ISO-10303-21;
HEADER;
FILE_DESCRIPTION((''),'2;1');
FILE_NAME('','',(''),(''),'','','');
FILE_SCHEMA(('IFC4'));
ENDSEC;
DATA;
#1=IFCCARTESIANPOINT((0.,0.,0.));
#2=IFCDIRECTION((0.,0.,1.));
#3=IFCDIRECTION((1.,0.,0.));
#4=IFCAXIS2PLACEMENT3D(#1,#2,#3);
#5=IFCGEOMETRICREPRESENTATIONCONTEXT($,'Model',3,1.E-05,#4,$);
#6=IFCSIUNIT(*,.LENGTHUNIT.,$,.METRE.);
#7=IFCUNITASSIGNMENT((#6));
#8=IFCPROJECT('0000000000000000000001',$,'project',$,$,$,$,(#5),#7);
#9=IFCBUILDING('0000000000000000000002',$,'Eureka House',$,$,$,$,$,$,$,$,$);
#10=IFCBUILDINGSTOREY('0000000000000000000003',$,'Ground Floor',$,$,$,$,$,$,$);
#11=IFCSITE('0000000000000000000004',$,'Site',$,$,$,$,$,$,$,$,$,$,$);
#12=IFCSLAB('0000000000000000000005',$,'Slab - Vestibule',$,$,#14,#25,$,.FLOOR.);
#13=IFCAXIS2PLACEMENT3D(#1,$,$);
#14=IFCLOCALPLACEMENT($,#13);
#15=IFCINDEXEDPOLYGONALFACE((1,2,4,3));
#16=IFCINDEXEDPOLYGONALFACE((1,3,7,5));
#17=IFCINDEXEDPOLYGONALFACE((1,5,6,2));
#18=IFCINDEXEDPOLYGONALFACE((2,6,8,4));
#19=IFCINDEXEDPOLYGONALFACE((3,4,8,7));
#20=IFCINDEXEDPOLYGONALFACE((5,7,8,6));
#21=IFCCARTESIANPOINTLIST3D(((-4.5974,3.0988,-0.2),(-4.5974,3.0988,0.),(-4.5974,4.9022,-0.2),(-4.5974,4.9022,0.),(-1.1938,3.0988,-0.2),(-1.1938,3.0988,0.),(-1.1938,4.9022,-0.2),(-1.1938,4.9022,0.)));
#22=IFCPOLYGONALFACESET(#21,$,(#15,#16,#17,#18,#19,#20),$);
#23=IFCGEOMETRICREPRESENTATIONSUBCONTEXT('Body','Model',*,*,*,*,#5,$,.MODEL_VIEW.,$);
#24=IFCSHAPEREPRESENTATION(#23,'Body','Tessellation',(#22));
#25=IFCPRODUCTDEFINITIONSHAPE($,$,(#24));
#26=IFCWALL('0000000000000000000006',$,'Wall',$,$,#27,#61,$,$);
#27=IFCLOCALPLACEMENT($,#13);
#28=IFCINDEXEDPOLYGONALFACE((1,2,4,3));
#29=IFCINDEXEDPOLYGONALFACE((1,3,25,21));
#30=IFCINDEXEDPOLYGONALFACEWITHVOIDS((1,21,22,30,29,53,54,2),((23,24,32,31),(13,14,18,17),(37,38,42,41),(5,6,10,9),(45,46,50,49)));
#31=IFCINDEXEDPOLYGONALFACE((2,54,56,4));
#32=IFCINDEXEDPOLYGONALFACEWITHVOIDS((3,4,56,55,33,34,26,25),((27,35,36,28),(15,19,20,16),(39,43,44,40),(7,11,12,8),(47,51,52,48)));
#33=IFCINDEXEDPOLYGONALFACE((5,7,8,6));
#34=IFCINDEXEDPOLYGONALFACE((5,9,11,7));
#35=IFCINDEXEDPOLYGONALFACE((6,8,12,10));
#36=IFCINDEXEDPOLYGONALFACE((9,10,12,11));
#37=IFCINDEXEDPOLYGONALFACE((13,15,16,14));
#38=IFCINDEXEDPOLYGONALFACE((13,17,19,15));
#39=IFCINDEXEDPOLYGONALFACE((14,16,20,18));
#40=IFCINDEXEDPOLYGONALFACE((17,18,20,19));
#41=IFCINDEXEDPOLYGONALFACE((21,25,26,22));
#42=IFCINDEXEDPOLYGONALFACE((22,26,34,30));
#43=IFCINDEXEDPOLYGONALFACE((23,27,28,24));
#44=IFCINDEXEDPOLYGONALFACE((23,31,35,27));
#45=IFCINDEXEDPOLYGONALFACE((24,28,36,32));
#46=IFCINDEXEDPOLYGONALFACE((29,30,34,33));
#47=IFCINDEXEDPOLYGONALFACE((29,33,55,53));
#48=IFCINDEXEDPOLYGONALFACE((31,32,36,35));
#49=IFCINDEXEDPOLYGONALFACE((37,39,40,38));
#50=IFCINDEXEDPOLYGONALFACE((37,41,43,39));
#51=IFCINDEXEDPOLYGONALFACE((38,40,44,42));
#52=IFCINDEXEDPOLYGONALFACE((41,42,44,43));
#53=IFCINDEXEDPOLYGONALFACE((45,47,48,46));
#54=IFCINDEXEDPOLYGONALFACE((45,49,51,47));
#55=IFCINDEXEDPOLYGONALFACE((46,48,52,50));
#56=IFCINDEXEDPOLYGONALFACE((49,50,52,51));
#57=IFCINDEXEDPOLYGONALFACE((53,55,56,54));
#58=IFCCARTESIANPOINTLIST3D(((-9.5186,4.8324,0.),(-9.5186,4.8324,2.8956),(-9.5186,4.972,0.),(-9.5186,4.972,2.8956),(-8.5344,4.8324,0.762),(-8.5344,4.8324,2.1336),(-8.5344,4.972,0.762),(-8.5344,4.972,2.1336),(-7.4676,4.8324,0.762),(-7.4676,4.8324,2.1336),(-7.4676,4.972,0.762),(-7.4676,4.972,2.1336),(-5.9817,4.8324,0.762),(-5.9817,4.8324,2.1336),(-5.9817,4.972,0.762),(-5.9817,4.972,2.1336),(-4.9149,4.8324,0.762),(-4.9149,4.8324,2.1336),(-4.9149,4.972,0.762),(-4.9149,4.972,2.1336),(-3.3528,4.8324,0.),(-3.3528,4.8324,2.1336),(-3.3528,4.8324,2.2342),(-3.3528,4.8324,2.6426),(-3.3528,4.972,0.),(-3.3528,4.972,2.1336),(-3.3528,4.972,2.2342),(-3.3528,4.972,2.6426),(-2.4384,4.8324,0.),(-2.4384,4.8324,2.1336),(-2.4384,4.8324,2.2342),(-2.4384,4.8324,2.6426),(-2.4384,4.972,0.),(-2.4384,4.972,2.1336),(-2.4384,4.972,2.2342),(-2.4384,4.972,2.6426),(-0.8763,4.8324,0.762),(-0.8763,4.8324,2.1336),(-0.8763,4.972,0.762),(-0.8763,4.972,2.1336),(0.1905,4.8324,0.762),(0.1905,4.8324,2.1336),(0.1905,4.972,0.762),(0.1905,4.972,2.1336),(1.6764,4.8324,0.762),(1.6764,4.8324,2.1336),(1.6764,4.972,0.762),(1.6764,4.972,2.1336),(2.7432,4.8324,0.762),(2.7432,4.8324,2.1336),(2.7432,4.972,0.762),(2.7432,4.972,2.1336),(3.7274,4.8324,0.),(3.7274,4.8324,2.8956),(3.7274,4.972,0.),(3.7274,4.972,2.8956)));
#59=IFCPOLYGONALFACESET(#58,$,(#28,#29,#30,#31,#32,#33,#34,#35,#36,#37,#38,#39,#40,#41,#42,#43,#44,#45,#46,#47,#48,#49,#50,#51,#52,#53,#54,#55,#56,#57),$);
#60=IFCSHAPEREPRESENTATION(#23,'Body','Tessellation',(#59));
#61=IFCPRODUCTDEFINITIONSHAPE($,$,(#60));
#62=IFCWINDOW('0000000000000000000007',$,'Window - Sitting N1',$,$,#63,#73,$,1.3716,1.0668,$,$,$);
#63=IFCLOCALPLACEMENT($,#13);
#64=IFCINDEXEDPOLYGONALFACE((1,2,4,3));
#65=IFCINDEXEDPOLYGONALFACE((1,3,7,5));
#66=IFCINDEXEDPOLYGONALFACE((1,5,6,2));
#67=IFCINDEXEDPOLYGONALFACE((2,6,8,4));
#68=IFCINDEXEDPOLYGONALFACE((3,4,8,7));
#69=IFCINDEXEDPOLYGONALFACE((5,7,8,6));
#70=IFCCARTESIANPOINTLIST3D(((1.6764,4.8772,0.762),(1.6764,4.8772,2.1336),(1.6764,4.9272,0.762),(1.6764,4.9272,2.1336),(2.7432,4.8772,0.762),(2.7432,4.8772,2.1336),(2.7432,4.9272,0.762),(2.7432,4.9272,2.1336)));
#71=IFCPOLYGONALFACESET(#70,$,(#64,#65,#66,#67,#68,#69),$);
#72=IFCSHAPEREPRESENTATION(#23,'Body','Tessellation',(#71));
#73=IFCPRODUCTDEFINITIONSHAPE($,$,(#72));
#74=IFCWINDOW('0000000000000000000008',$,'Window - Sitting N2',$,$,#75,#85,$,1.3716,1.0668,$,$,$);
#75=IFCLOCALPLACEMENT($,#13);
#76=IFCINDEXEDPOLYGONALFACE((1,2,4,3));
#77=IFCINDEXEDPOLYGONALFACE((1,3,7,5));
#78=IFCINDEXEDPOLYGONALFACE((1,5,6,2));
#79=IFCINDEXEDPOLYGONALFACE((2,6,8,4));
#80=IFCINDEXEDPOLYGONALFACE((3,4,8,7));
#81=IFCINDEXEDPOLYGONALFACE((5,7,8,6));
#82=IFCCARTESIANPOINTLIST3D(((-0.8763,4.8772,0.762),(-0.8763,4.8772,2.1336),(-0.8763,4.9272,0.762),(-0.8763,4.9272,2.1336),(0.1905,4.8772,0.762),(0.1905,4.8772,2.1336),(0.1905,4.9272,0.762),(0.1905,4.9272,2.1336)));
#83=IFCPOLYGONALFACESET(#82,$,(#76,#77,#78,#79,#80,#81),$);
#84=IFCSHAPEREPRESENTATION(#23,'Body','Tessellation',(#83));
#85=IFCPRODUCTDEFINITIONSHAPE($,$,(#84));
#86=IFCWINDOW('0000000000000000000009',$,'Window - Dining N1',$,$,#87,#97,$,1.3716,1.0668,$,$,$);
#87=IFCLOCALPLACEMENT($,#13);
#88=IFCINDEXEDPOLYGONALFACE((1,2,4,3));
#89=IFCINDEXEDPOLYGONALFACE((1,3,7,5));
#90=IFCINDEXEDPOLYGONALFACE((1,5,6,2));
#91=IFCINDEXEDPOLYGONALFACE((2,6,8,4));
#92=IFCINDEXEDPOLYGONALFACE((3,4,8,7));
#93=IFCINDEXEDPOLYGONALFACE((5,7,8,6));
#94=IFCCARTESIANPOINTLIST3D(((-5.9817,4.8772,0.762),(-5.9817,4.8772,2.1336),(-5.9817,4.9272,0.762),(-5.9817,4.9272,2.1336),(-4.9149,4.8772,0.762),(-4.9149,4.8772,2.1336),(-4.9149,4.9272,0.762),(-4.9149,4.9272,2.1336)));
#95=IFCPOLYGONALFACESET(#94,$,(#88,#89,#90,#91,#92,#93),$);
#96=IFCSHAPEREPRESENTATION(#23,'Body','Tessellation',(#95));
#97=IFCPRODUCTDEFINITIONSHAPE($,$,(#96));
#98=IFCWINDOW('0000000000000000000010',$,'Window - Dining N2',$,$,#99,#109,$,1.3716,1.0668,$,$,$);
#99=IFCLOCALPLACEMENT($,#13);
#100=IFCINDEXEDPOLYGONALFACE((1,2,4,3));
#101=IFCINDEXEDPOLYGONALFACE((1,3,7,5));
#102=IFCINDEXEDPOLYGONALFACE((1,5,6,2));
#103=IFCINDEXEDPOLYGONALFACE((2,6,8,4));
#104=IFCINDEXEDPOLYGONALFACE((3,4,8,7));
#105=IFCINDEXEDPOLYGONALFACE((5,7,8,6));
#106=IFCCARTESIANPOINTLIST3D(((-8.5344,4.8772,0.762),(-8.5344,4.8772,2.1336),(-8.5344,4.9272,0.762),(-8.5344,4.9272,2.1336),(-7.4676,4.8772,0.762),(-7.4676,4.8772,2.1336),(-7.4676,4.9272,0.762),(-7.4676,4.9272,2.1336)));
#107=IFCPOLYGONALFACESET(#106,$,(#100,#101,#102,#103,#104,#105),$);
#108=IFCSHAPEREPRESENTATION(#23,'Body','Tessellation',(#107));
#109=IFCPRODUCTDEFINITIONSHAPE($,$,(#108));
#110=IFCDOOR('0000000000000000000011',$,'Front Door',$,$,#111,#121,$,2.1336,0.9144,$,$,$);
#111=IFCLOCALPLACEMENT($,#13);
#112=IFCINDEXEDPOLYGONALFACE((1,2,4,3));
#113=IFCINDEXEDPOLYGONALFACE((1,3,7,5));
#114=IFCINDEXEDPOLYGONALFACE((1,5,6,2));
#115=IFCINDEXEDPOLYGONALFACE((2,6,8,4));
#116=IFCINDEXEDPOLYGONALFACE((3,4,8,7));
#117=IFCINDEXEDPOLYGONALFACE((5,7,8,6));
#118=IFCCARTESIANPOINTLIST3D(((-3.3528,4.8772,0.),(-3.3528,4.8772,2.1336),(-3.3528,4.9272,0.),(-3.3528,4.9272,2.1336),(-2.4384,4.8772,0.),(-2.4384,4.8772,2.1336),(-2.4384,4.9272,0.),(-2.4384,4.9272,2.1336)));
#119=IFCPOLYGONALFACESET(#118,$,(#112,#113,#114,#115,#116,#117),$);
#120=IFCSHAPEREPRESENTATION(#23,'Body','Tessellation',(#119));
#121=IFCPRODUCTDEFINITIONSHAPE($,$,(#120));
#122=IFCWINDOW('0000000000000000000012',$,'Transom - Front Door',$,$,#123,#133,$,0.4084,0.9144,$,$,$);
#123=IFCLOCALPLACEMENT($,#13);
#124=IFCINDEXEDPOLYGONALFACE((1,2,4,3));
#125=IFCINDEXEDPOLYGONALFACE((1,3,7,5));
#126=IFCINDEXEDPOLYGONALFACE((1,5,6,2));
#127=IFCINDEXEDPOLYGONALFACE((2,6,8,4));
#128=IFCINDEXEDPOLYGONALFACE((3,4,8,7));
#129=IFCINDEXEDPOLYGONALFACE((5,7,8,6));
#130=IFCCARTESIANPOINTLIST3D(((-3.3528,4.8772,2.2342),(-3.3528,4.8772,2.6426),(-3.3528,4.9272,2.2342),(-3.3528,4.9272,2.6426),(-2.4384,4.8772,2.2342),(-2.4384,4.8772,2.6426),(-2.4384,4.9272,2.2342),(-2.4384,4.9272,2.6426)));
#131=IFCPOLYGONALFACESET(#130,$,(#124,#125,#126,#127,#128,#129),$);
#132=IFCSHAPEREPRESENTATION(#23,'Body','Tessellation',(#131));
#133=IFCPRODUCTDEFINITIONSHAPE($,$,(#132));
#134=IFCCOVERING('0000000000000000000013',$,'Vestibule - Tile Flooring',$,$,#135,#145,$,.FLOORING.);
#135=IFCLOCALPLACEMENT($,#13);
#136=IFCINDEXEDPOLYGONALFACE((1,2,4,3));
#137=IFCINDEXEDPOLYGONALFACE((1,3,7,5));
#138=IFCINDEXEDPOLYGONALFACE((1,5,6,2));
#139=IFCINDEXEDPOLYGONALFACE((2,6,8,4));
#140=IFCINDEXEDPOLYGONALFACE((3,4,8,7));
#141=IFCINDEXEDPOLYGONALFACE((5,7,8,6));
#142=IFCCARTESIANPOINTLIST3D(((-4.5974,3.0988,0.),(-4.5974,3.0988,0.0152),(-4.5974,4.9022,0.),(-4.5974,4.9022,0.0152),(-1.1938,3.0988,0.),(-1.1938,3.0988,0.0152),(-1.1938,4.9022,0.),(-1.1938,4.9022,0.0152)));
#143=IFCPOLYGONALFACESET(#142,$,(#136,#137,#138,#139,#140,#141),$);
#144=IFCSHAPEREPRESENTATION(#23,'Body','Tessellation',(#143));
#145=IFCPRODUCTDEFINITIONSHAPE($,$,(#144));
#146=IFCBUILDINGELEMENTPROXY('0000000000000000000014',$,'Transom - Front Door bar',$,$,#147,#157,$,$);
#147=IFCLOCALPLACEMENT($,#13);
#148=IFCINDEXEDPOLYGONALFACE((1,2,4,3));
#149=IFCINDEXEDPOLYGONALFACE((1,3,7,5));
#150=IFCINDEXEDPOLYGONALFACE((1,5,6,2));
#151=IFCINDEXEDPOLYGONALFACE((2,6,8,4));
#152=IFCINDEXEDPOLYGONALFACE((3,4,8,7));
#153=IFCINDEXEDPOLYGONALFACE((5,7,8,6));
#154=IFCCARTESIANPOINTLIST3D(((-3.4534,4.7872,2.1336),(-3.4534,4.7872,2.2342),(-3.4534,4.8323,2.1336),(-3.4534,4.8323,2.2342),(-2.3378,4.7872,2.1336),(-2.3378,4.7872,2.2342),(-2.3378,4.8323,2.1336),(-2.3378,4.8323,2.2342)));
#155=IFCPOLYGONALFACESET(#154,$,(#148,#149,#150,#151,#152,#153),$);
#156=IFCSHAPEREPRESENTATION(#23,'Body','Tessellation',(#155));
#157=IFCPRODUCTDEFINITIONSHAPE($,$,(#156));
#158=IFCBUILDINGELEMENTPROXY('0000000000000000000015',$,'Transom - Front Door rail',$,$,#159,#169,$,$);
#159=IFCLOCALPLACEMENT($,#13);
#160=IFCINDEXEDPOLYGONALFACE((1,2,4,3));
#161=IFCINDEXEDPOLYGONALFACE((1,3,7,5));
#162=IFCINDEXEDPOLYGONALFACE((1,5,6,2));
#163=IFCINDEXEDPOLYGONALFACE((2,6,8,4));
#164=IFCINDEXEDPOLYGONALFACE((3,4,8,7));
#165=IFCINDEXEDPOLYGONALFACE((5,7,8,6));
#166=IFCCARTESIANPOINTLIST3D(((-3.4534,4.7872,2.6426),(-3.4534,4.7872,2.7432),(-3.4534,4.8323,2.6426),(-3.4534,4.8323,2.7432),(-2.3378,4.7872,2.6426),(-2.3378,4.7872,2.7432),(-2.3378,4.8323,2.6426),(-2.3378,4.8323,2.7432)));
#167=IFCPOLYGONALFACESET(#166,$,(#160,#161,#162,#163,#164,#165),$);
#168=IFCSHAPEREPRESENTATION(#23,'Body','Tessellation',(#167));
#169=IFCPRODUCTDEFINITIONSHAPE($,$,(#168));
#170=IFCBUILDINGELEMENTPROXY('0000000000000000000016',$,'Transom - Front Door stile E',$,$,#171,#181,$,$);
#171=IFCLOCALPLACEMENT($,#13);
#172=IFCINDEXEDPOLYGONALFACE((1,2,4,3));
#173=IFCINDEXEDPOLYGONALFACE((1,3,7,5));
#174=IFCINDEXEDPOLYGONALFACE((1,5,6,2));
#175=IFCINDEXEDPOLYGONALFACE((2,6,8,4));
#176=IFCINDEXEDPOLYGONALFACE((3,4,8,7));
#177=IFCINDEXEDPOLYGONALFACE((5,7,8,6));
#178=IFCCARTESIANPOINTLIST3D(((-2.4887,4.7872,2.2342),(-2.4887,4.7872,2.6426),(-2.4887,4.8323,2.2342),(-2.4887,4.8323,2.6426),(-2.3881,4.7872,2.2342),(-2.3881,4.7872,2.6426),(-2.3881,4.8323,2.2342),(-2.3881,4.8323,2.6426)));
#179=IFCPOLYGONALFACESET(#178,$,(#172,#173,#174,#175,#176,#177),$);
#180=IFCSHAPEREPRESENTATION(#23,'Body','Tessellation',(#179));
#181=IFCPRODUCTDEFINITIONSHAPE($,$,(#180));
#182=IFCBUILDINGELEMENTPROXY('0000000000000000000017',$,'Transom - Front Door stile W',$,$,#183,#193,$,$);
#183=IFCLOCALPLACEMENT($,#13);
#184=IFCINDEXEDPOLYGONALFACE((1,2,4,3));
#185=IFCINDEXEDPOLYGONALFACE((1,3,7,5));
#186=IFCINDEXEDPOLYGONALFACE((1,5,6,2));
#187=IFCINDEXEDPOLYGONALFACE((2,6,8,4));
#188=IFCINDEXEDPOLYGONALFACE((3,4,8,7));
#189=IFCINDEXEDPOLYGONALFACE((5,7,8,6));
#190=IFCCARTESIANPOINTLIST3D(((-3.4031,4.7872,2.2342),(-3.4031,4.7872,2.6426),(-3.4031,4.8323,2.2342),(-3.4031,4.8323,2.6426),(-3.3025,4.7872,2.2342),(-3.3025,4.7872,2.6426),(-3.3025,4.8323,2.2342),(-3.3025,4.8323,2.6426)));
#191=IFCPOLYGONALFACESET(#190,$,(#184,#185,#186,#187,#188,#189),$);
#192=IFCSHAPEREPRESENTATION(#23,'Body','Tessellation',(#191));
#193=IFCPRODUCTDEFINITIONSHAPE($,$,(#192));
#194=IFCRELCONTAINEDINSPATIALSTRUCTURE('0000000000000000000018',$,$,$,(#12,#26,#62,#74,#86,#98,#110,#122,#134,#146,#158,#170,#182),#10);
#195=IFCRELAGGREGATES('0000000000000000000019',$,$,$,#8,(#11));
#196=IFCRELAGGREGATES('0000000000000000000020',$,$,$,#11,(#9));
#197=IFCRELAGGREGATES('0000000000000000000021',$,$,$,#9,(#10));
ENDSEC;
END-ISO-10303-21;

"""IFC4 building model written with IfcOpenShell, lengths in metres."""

from ifc_helpers import new_model, si_unit, frame, origin, origin_with_axes, origin_2d, place, context, subcontext, project, spatial, rectangle, extrude, element, fill, save


model = new_model("IFC4")

# Units and contexts
model_context = context("Model", 3, precision=1e-05, world=origin_with_axes())
body_context = subcontext(model_context, "Body", "Model", "MODEL_VIEW")
ifc_project = project(units=[si_unit("LENGTHUNIT", "METRE")], contexts=[model_context])

# Site, building, storey
site = spatial("IfcSite", under=ifc_project, Name="Site")
building = spatial("IfcBuilding", under=site, Name="Eureka House")
storey = spatial("IfcBuildingStorey", under=building, Name="Ground Floor")

# Slab
slab_placement = place(None, frame((-2.8956, 4.0005, -0.2), z_axis=(0.0, 0.0, 1.0), x_axis=(1.0, 0.0, 0.0)))
element("IfcSlab", 1, at=slab_placement, inside=storey, Name="Slab - Vestibule", PredefinedType="FLOOR", context=body_context, shape_type="SweptSolid", body=[
    extrude(rectangle(XDim=3.4036, YDim=1.8034, at=origin_2d()), origin(), (0.0, 0.0, 1.0), 0.2),
])

# Wall, openings, windows, door
wall_placement = place(None, frame((-2.8956, 4.9022, 0.0), z_axis=(0.0, 0.0, 1.0), x_axis=(1.0, 0.0, 0.0)))
wall = element("IfcWall", 2, at=wall_placement, inside=storey, Name="Wall", context=body_context, shape_type="SweptSolid", body=[
    extrude(rectangle(XDim=13.2461, YDim=0.1397, at=origin_2d()), origin(), (0.0, 0.0, 1.0), 2.8956),
])
opening_1_placement = place(wall_placement, frame((5.1054, 0.0, 0.762), z_axis=(0.0, 0.0, 1.0), x_axis=(1.0, 0.0, 0.0)))
opening_1 = element("IfcOpeningElement", 3, at=opening_1_placement, cuts=wall, context=body_context, shape_type="SweptSolid", body=[
    extrude(rectangle(XDim=1.0668, YDim=0.2397, at=origin_2d()), origin(), (0.0, 0.0, 1.0), 1.3716),
])
opening_2_placement = place(wall_placement, frame((2.5527, 0.0, 0.762), z_axis=(0.0, 0.0, 1.0), x_axis=(1.0, 0.0, 0.0)))
opening_2 = element("IfcOpeningElement", 4, at=opening_2_placement, cuts=wall, context=body_context, shape_type="SweptSolid", body=[
    extrude(rectangle(XDim=1.0668, YDim=0.2397, at=origin_2d()), origin(), (0.0, 0.0, 1.0), 1.3716),
])
opening_3_placement = place(wall_placement, frame((-2.5527, 0.0, 0.762), z_axis=(0.0, 0.0, 1.0), x_axis=(1.0, 0.0, 0.0)))
opening_3 = element("IfcOpeningElement", 5, at=opening_3_placement, cuts=wall, context=body_context, shape_type="SweptSolid", body=[
    extrude(rectangle(XDim=1.0668, YDim=0.2397, at=origin_2d()), origin(), (0.0, 0.0, 1.0), 1.3716),
])
opening_4_placement = place(wall_placement, frame((-5.1054, 0.0, 0.762), z_axis=(0.0, 0.0, 1.0), x_axis=(1.0, 0.0, 0.0)))
opening_4 = element("IfcOpeningElement", 6, at=opening_4_placement, cuts=wall, context=body_context, shape_type="SweptSolid", body=[
    extrude(rectangle(XDim=1.0668, YDim=0.2397, at=origin_2d()), origin(), (0.0, 0.0, 1.0), 1.3716),
])
opening_5_placement = place(wall_placement, frame((0.0, 0.0, 0.0), z_axis=(0.0, 0.0, 1.0), x_axis=(1.0, 0.0, 0.0)))
opening_5 = element("IfcOpeningElement", 7, at=opening_5_placement, cuts=wall, context=body_context, shape_type="SweptSolid", body=[
    extrude(rectangle(XDim=0.9144, YDim=0.2397, at=origin_2d()), origin(), (0.0, 0.0, 1.0), 2.1336),
])
opening_6_placement = place(wall_placement, frame((0.0, 0.0, 2.2342), z_axis=(0.0, 0.0, 1.0), x_axis=(1.0, 0.0, 0.0)))
opening_6 = element("IfcOpeningElement", 8, at=opening_6_placement, cuts=wall, context=body_context, shape_type="SweptSolid", body=[
    extrude(rectangle(XDim=0.9144, YDim=0.2397, at=origin_2d()), origin(), (0.0, 0.0, 1.0), 0.4084),
])
window_1_placement = place(opening_1_placement, frame((0.0, 0.0, 0.0), z_axis=(0.0, 0.0, 1.0), x_axis=(1.0, 0.0, 0.0)))
window_1 = element("IfcWindow", 9, at=window_1_placement, inside=storey, Name="Window - Sitting N1", OverallHeight=1.3716, OverallWidth=1.0668, context=body_context, shape_type="SweptSolid", body=[
    extrude(rectangle(XDim=1.0668, YDim=0.05, at=origin_2d()), origin(), (0.0, 0.0, 1.0), 1.3716),
])
fill(opening_1, window_1)
window_2_placement = place(opening_2_placement, frame((0.0, 0.0, 0.0), z_axis=(0.0, 0.0, 1.0), x_axis=(1.0, 0.0, 0.0)))
window_2 = element("IfcWindow", 10, at=window_2_placement, inside=storey, Name="Window - Sitting N2", OverallHeight=1.3716, OverallWidth=1.0668, context=body_context, shape_type="SweptSolid", body=[
    extrude(rectangle(XDim=1.0668, YDim=0.05, at=origin_2d()), origin(), (0.0, 0.0, 1.0), 1.3716),
])
fill(opening_2, window_2)
window_3_placement = place(opening_3_placement, origin_with_axes())
window_3 = element("IfcWindow", 11, at=window_3_placement, inside=storey, Name="Window - Dining N1", OverallHeight=1.3716, OverallWidth=1.0668, context=body_context, shape_type="SweptSolid", body=[
    extrude(rectangle(XDim=1.0668, YDim=0.05, at=origin_2d()), origin(), (0.0, 0.0, 1.0), 1.3716),
])
fill(opening_3, window_3)
window_4_placement = place(opening_4_placement, origin_with_axes())
window_4 = element("IfcWindow", 12, at=window_4_placement, inside=storey, Name="Window - Dining N2", OverallHeight=1.3716, OverallWidth=1.0668, context=body_context, shape_type="SweptSolid", body=[
    extrude(rectangle(XDim=1.0668, YDim=0.05, at=origin_2d()), origin(), (0.0, 0.0, 1.0), 1.3716),
])
fill(opening_4, window_4)
door_placement = place(opening_5_placement, origin_with_axes())
door = element("IfcDoor", 13, at=door_placement, inside=storey, Name="Front Door", OverallHeight=2.1336, OverallWidth=0.9144, context=body_context, shape_type="SweptSolid", body=[
    extrude(rectangle(XDim=0.9144, YDim=0.05, at=origin_2d()), origin(), (0.0, 0.0, 1.0), 2.1336),
])
fill(opening_5, door)
window_5_placement = place(opening_6_placement, origin_with_axes())
window_5 = element("IfcWindow", 14, at=window_5_placement, inside=storey, Name="Transom - Front Door", OverallHeight=0.4084, OverallWidth=0.9144, context=body_context, shape_type="SweptSolid", body=[
    extrude(rectangle(XDim=0.9144, YDim=0.05, at=origin_2d()), origin(), (0.0, 0.0, 1.0), 0.4084),
])
fill(opening_6, window_5)

# Covering
covering_placement = place(None, frame((-2.8956, 4.0005, 0.0), z_axis=(0.0, 0.0, 1.0), x_axis=(1.0, 0.0, 0.0)))
element("IfcCovering", 15, at=covering_placement, inside=storey, Name="Vestibule - Tile Flooring", PredefinedType="FLOORING", context=body_context, shape_type="SweptSolid", body=[
    extrude(rectangle(XDim=3.4036, YDim=1.8034, at=origin_2d()), origin(), (0.0, 0.0, 1.0), 0.0152),
])

# Building element proxies
for number, where, z_axis, x_axis, name in (
    (16, (-2.8956, 4.8098, 2.1336), (0.0, 0.0, 1.0), (1.0, 0.0, 0.0), "Transom - Front Door bar"),
    (17, (-2.8956, 4.8098, 2.6426), (0.0, 0.0, 1.0), (1.0, 0.0, 0.0), "Transom - Front Door rail"),
):
    element("IfcBuildingElementProxy", number, at=place(None, frame(where, z_axis=z_axis, x_axis=x_axis)), inside=storey, Name=name, context=body_context, shape_type="SweptSolid", body=[
        extrude(rectangle(XDim=1.1156, YDim=0.0451, at=origin_2d()), origin(), (0.0, 0.0, 1.0), 0.1006),
    ])
for number, where, z_axis, x_axis, name in (
    (18, (-2.4384, 4.8098, 2.2342), (0.0, 0.0, 1.0), (1.0, 0.0, 0.0), "Transom - Front Door stile E"),
    (19, (-3.3528, 4.8098, 2.2342), (0.0, 0.0, 1.0), (1.0, 0.0, 0.0), "Transom - Front Door stile W"),
):
    element("IfcBuildingElementProxy", number, at=place(None, frame(where, z_axis=z_axis, x_axis=x_axis)), inside=storey, Name=name, context=body_context, shape_type="SweptSolid", body=[
        extrude(rectangle(XDim=0.1006, YDim=0.0451, at=origin_2d()), origin(), (0.0, 0.0, 1.0), 0.4084),
    ])

save(model, "model.ifc")
